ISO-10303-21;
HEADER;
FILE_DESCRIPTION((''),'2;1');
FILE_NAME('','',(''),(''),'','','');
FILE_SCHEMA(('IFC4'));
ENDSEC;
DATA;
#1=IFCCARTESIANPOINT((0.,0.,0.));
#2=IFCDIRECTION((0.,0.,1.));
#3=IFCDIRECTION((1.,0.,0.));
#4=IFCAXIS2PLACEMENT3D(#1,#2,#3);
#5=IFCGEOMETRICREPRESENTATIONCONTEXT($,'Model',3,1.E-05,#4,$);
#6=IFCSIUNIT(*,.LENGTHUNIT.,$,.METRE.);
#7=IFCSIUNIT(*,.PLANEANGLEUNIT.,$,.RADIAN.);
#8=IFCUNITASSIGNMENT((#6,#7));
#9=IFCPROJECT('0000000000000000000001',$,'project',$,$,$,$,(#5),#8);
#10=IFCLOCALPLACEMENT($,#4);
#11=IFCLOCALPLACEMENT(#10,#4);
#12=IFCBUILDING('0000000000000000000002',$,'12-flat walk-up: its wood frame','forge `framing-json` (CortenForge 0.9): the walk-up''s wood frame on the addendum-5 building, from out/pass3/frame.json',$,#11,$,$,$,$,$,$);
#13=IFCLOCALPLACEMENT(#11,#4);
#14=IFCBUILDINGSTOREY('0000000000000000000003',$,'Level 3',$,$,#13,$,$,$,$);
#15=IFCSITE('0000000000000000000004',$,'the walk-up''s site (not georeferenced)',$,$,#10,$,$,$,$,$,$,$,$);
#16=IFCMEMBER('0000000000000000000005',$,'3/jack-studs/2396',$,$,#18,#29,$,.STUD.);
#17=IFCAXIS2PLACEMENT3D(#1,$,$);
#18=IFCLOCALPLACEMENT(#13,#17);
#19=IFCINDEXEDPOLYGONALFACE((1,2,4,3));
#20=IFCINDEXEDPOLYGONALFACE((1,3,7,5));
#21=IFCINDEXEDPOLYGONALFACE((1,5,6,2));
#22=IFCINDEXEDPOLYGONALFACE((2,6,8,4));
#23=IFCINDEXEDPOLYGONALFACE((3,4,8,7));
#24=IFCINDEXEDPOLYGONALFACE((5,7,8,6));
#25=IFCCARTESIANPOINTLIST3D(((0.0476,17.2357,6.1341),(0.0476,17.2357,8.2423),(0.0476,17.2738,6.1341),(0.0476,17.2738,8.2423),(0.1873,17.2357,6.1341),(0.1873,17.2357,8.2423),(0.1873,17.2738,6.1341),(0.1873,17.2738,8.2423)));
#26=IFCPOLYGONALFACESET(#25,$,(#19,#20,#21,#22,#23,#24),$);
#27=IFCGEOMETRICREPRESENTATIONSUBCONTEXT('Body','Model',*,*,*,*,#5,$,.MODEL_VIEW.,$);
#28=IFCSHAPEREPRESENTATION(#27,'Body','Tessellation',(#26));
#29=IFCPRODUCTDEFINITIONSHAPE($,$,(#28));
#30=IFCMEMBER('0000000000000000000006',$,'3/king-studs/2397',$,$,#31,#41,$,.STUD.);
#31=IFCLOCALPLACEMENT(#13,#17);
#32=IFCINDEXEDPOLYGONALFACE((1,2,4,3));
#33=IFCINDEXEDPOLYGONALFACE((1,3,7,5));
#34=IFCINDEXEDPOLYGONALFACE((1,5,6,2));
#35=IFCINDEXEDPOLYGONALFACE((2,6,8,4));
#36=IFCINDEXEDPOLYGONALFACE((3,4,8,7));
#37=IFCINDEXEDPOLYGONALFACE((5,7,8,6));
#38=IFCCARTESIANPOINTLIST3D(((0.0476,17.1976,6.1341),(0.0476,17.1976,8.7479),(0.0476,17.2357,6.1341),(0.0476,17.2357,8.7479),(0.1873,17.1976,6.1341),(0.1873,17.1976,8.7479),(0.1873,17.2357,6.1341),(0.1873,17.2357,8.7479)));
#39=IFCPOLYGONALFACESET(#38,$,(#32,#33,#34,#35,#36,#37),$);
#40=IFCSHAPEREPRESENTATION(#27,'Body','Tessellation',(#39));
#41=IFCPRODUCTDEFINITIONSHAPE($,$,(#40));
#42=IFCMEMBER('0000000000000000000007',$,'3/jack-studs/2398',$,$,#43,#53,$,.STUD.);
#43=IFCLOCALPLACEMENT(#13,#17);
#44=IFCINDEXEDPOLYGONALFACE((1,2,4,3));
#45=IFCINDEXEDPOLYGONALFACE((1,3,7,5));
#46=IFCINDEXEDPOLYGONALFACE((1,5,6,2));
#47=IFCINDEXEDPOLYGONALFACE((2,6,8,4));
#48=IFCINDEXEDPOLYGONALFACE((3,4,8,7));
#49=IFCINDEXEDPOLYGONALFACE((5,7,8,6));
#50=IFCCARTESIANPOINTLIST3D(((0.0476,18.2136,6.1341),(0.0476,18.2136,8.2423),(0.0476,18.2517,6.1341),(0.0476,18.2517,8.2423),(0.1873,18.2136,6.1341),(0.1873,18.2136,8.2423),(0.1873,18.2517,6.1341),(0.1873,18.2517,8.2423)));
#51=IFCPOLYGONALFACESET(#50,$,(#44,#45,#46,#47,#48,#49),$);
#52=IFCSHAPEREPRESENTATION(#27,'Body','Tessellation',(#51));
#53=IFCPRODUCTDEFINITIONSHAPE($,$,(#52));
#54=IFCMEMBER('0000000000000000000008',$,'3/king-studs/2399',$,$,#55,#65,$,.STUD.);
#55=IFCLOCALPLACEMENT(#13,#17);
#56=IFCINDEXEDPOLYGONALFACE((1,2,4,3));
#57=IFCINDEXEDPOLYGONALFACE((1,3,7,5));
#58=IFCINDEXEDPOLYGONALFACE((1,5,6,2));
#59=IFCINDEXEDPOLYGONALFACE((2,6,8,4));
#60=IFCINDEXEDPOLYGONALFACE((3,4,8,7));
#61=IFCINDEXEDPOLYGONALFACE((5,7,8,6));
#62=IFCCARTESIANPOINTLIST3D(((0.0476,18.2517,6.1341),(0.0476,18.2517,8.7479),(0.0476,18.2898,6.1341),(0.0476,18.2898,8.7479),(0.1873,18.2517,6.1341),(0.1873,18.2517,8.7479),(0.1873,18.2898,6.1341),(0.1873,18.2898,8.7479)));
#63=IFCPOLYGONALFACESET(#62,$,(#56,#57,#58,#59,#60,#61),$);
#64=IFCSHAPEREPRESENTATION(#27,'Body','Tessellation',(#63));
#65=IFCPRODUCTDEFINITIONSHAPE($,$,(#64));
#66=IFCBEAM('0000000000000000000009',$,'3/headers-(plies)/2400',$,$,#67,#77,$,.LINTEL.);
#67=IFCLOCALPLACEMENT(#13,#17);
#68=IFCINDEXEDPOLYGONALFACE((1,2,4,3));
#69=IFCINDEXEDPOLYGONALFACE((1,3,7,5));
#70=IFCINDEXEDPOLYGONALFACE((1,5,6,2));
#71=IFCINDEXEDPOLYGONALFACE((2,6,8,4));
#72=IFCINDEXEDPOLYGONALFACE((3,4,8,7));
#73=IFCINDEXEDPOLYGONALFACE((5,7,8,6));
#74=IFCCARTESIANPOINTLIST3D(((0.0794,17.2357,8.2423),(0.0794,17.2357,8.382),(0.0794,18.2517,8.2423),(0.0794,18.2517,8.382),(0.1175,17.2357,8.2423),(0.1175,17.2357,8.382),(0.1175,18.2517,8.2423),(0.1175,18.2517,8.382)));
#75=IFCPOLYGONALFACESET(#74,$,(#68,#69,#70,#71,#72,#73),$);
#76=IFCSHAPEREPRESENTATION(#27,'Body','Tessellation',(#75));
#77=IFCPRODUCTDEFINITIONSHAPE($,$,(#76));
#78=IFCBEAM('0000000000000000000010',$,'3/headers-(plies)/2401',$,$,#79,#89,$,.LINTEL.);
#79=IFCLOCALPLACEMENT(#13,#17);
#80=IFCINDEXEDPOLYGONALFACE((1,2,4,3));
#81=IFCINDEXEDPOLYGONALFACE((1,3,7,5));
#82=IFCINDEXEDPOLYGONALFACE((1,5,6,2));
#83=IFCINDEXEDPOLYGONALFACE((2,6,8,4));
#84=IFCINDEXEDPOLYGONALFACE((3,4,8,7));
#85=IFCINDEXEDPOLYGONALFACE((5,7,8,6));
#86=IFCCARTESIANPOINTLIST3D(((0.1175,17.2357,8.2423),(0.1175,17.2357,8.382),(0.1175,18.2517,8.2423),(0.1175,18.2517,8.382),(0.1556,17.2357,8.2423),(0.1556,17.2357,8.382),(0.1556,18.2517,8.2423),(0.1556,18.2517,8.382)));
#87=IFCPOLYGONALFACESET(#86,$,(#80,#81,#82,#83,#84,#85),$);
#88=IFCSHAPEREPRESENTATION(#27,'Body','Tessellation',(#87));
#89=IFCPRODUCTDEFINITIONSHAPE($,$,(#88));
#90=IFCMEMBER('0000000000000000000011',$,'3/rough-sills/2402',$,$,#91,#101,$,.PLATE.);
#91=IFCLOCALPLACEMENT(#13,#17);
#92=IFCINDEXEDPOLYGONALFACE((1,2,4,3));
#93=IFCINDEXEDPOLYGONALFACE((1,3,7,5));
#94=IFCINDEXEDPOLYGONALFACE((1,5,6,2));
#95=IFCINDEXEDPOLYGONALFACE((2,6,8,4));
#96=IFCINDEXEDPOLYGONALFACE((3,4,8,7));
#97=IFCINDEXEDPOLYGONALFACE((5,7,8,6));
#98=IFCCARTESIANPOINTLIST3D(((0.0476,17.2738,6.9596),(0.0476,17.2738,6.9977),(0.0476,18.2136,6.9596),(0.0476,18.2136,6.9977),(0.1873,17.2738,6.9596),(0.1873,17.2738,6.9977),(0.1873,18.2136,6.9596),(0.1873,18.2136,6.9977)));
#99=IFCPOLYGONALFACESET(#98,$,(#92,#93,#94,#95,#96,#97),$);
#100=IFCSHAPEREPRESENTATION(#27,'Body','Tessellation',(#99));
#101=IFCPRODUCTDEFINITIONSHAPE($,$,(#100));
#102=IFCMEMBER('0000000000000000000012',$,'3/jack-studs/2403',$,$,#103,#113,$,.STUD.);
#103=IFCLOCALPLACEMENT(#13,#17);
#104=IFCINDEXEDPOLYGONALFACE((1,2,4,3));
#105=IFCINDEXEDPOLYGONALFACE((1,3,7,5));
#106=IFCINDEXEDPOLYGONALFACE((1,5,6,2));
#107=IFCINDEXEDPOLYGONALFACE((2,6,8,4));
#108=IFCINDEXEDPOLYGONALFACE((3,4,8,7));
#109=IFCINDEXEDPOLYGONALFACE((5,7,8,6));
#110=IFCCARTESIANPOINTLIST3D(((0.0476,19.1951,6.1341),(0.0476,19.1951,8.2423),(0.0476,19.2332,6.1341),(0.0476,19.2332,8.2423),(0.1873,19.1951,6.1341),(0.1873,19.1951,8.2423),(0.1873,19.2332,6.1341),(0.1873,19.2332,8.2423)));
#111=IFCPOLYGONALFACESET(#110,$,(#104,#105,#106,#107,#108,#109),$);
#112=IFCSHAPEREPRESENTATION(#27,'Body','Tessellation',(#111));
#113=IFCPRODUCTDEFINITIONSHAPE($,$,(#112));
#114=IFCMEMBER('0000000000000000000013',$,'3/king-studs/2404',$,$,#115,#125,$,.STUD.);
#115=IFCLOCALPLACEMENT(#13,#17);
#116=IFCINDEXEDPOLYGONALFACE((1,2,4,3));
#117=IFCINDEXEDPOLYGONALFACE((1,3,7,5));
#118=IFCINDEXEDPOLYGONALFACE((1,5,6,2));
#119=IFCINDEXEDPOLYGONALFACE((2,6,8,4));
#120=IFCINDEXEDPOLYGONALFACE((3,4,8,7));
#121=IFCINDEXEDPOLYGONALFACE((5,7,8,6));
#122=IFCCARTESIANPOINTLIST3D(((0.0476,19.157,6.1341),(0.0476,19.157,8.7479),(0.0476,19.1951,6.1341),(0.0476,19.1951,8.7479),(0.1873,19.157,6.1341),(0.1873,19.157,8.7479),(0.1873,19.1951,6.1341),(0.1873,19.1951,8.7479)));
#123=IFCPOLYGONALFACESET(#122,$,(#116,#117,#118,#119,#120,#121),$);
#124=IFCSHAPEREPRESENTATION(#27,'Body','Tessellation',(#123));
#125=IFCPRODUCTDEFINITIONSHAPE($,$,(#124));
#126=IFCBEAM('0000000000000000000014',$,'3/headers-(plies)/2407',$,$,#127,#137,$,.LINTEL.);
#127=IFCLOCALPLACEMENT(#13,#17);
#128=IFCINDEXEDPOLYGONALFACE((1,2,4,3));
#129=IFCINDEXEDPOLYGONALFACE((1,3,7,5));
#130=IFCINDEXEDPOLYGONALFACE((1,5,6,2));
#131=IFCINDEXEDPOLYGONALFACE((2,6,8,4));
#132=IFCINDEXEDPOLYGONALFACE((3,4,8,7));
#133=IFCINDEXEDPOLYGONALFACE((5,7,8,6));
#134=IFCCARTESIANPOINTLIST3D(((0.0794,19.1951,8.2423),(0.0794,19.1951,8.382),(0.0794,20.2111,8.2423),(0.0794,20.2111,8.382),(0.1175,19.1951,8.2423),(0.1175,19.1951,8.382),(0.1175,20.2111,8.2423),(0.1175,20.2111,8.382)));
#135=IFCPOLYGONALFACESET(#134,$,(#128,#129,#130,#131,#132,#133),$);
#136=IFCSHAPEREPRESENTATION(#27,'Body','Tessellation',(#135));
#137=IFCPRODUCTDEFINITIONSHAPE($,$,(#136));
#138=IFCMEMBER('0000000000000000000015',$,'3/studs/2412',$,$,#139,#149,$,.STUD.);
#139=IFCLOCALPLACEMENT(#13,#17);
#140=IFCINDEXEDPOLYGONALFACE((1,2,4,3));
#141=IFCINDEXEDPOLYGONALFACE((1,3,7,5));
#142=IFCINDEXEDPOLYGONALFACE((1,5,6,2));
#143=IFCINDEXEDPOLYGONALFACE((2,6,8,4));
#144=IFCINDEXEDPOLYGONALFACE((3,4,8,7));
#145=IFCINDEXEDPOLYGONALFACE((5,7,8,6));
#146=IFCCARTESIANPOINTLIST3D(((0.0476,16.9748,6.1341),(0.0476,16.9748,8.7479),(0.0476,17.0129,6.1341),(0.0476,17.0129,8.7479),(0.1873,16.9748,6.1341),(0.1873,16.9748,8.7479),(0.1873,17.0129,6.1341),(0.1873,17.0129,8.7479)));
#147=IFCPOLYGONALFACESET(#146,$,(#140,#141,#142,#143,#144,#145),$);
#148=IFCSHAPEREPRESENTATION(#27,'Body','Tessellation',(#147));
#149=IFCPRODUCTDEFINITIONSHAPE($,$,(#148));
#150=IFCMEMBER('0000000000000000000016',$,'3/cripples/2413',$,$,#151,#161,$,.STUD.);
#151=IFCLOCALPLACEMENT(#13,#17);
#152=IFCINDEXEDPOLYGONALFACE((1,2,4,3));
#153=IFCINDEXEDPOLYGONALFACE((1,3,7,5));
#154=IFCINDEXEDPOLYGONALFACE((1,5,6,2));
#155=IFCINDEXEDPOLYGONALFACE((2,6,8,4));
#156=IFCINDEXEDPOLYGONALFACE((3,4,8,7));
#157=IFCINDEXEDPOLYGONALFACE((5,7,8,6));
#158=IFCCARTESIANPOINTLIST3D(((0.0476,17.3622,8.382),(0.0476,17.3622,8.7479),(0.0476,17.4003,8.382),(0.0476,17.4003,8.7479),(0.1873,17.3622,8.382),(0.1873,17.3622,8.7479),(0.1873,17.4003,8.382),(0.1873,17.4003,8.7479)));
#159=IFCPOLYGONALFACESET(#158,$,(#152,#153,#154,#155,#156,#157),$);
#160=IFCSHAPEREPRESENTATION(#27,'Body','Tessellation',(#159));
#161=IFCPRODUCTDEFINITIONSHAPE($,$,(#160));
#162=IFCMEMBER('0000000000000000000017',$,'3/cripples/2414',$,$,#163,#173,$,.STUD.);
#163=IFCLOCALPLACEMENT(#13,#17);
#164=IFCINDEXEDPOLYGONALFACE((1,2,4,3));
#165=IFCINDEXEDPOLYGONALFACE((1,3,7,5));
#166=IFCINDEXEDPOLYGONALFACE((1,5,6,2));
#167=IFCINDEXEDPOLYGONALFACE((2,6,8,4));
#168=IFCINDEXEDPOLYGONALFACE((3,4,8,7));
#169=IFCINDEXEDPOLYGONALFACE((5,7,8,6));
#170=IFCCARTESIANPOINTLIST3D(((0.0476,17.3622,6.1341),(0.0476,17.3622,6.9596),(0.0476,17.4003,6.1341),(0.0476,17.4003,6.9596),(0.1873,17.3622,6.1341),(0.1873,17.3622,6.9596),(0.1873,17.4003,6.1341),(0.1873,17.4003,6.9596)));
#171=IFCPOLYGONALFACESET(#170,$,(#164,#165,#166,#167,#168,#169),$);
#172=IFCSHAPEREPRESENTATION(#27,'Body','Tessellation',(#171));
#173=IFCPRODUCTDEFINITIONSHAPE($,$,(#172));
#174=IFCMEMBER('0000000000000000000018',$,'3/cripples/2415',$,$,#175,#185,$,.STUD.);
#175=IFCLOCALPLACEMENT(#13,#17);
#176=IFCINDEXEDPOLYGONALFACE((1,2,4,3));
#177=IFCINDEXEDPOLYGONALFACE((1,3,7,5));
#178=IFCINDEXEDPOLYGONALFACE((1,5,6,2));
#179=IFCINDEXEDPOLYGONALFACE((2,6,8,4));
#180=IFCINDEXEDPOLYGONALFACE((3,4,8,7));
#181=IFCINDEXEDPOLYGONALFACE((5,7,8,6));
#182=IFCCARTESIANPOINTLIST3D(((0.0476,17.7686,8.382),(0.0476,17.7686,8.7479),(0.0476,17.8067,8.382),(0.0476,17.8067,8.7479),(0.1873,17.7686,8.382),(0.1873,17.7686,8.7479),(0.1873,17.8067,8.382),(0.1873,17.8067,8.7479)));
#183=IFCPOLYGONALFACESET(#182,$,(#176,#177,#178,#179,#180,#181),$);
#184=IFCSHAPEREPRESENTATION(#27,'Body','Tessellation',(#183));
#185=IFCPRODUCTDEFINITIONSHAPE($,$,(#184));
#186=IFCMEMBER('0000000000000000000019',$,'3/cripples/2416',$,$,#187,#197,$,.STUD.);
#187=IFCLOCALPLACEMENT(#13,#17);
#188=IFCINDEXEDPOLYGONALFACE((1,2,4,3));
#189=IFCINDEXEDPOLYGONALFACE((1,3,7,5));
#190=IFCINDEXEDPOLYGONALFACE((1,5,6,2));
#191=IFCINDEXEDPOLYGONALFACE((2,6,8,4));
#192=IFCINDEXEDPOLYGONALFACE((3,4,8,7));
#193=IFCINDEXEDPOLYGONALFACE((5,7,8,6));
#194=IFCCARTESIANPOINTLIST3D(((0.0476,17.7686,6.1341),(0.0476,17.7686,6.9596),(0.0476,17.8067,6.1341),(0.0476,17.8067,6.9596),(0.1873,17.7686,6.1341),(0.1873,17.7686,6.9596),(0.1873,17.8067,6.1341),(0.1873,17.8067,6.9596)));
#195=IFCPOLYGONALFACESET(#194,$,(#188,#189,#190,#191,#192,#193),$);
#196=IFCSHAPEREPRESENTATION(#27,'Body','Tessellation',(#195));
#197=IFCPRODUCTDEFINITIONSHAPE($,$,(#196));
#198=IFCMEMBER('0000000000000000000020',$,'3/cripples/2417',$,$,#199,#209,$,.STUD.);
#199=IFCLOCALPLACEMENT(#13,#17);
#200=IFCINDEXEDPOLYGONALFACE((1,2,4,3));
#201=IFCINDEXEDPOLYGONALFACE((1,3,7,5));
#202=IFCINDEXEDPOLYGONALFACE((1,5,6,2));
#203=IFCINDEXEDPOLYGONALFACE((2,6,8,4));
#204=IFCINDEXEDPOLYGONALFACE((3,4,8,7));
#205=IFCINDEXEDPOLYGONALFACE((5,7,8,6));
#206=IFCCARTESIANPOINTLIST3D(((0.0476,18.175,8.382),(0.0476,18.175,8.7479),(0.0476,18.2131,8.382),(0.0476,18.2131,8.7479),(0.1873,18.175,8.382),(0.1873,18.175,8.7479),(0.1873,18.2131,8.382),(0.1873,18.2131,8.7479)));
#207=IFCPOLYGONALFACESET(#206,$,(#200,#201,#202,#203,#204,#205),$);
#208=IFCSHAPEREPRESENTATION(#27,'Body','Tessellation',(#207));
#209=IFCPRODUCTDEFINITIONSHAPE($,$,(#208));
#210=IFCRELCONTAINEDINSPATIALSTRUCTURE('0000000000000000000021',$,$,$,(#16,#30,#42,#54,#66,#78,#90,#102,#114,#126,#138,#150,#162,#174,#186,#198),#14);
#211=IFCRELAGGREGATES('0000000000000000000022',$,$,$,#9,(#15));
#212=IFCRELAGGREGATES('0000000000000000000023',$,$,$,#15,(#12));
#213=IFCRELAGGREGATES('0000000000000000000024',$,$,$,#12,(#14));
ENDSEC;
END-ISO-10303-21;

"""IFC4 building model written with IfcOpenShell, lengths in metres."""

from ifc_helpers import new_model, si_unit, frame, frame_2d, origin, origin_with_axes, place, context, subcontext, project, spatial, rectangle, extrude, element, save


model = new_model("IFC4")

# Units and contexts
model_context = context("Model", 3, precision=1e-05, world=origin_with_axes())
body_context = subcontext(model_context, "Body", "Model", "MODEL_VIEW")
ifc_project = project(units=[si_unit("LENGTHUNIT", "METRE"), si_unit("PLANEANGLEUNIT", "RADIAN")], contexts=[model_context])

# Site, building, storey
site_placement = place(None, origin_with_axes())
site = spatial("IfcSite", under=ifc_project, at=site_placement, Name="the walk-up's site (not georeferenced)")
building_placement = place(site_placement, origin_with_axes())
building = spatial("IfcBuilding", under=site, at=building_placement, Name="12-flat walk-up: its wood frame", Description="forge `framing-json` (CortenForge 0.9): the walk-up's wood frame on the addendum-5 building, from out/pass3/frame.json")
storey_placement = place(building_placement, origin_with_axes())
storey = spatial("IfcBuildingStorey", under=building, at=storey_placement, Name="Level 3")

# Members
member_1_placement = place(storey_placement, frame((0.0476, 17.2357, 6.1341), z_axis=(0.0, 0.0, 1.0), x_axis=(1.0, 0.0, 0.0)))
element("IfcMember", 1, at=member_1_placement, inside=storey, Name="3/jack-studs/2396", PredefinedType="STUD", context=body_context, shape_type="SweptSolid", body=[
    extrude(rectangle(XDim=0.1397, YDim=0.0381, at=frame_2d((0.0698, 0.0191))), origin(), (0.0, 0.0, 1.0), 2.1082),
])
member_2_placement = place(storey_placement, frame((0.0476, 17.1976, 6.1341), z_axis=(0.0, 0.0, 1.0), x_axis=(1.0, 0.0, 0.0)))
element("IfcMember", 2, at=member_2_placement, inside=storey, Name="3/king-studs/2397", PredefinedType="STUD", context=body_context, shape_type="SweptSolid", body=[
    extrude(rectangle(XDim=0.1397, YDim=0.0381, at=frame_2d((0.0698, 0.0191))), origin(), (0.0, 0.0, 1.0), 2.6138),
])
member_3_placement = place(storey_placement, frame((0.0476, 18.2136, 6.1341), z_axis=(0.0, 0.0, 1.0), x_axis=(1.0, 0.0, 0.0)))
element("IfcMember", 3, at=member_3_placement, inside=storey, Name="3/jack-studs/2398", PredefinedType="STUD", context=body_context, shape_type="SweptSolid", body=[
    extrude(rectangle(XDim=0.1397, YDim=0.0381, at=frame_2d((0.0698, 0.0191))), origin(), (0.0, 0.0, 1.0), 2.1082),
])
member_4_placement = place(storey_placement, frame((0.0476, 18.2517, 6.1341), z_axis=(0.0, 0.0, 1.0), x_axis=(1.0, 0.0, 0.0)))
element("IfcMember", 4, at=member_4_placement, inside=storey, Name="3/king-studs/2399", PredefinedType="STUD", context=body_context, shape_type="SweptSolid", body=[
    extrude(rectangle(XDim=0.1397, YDim=0.0381, at=frame_2d((0.0698, 0.0191))), origin(), (0.0, 0.0, 1.0), 2.6138),
])

# Beams
for number, where, z_axis, x_axis, name in (
    (5, (0.0794, 17.2357, 8.2423), (0.0, 0.0, 1.0), (1.0, 0.0, 0.0), "3/headers-(plies)/2400"),
    (6, (0.1175, 17.2357, 8.2423), (0.0, 0.0, 1.0), (1.0, 0.0, 0.0), "3/headers-(plies)/2401"),
):
    element("IfcBeam", number, at=place(storey_placement, frame(where, z_axis=z_axis, x_axis=x_axis)), inside=storey, Name=name, PredefinedType="LINTEL", context=body_context, shape_type="SweptSolid", body=[
        extrude(rectangle(XDim=0.0381, YDim=1.016, at=frame_2d((0.019, 0.508))), origin(), (0.0, 0.0, 1.0), 0.1397),
    ])

# Members
member_5_placement = place(storey_placement, frame((0.0476, 17.2738, 6.9596), z_axis=(0.0, 0.0, 1.0), x_axis=(1.0, 0.0, 0.0)))
element("IfcMember", 7, at=member_5_placement, inside=storey, Name="3/rough-sills/2402", PredefinedType="PLATE", context=body_context, shape_type="SweptSolid", body=[
    extrude(rectangle(XDim=0.1397, YDim=0.9398, at=frame_2d((0.0698, 0.4699))), origin(), (0.0, 0.0, 1.0), 0.0381),
])
member_6_placement = place(storey_placement, frame((0.0476, 19.1951, 6.1341), z_axis=(0.0, 0.0, 1.0), x_axis=(1.0, 0.0, 0.0)))
element("IfcMember", 8, at=member_6_placement, inside=storey, Name="3/jack-studs/2403", PredefinedType="STUD", context=body_context, shape_type="SweptSolid", body=[
    extrude(rectangle(XDim=0.1397, YDim=0.0381, at=frame_2d((0.0698, 0.0191))), origin(), (0.0, 0.0, 1.0), 2.1082),
])
member_7_placement = place(storey_placement, frame((0.0476, 19.157, 6.1341), z_axis=(0.0, 0.0, 1.0), x_axis=(1.0, 0.0, 0.0)))
element("IfcMember", 9, at=member_7_placement, inside=storey, Name="3/king-studs/2404", PredefinedType="STUD", context=body_context, shape_type="SweptSolid", body=[
    extrude(rectangle(XDim=0.1397, YDim=0.0381, at=frame_2d((0.0698, 0.0191))), origin(), (0.0, 0.0, 1.0), 2.6138),
])

# Beam
beam_placement = place(storey_placement, frame((0.0794, 19.1951, 8.2423), z_axis=(0.0, 0.0, 1.0), x_axis=(1.0, 0.0, 0.0)))
element("IfcBeam", 10, at=beam_placement, inside=storey, Name="3/headers-(plies)/2407", PredefinedType="LINTEL", context=body_context, shape_type="SweptSolid", body=[
    extrude(rectangle(XDim=0.0381, YDim=1.016, at=frame_2d((0.019, 0.508))), origin(), (0.0, 0.0, 1.0), 0.1397),
])

# Members
member_8_placement = place(storey_placement, frame((0.0476, 16.9748, 6.1341), z_axis=(0.0, 0.0, 1.0), x_axis=(1.0, 0.0, 0.0)))
element("IfcMember", 11, at=member_8_placement, inside=storey, Name="3/studs/2412", PredefinedType="STUD", context=body_context, shape_type="SweptSolid", body=[
    extrude(rectangle(XDim=0.1397, YDim=0.0381, at=frame_2d((0.0698, 0.0191))), origin(), (0.0, 0.0, 1.0), 2.6138),
])
member_9_placement = place(storey_placement, frame((0.0476, 17.3622, 8.382), z_axis=(0.0, 0.0, 1.0), x_axis=(1.0, 0.0, 0.0)))
element("IfcMember", 12, at=member_9_placement, inside=storey, Name="3/cripples/2413", PredefinedType="STUD", context=body_context, shape_type="SweptSolid", body=[
    extrude(rectangle(XDim=0.1397, YDim=0.0381, at=frame_2d((0.0698, 0.0191))), origin(), (0.0, 0.0, 1.0), 0.3659),
])
member_10_placement = place(storey_placement, frame((0.0476, 17.3622, 6.1341), z_axis=(0.0, 0.0, 1.0), x_axis=(1.0, 0.0, 0.0)))
element("IfcMember", 13, at=member_10_placement, inside=storey, Name="3/cripples/2414", PredefinedType="STUD", context=body_context, shape_type="SweptSolid", body=[
    extrude(rectangle(XDim=0.1397, YDim=0.0381, at=frame_2d((0.0698, 0.0191))), origin(), (0.0, 0.0, 1.0), 0.8255),
])
member_11_placement = place(storey_placement, frame((0.0476, 17.7686, 8.382), z_axis=(0.0, 0.0, 1.0), x_axis=(1.0, 0.0, 0.0)))
element("IfcMember", 14, at=member_11_placement, inside=storey, Name="3/cripples/2415", PredefinedType="STUD", context=body_context, shape_type="SweptSolid", body=[
    extrude(rectangle(XDim=0.1397, YDim=0.0381, at=frame_2d((0.0698, 0.0191))), origin(), (0.0, 0.0, 1.0), 0.3659),
])
member_12_placement = place(storey_placement, frame((0.0476, 17.7686, 6.1341), z_axis=(0.0, 0.0, 1.0), x_axis=(1.0, 0.0, 0.0)))
element("IfcMember", 15, at=member_12_placement, inside=storey, Name="3/cripples/2416", PredefinedType="STUD", context=body_context, shape_type="SweptSolid", body=[
    extrude(rectangle(XDim=0.1397, YDim=0.0381, at=frame_2d((0.0698, 0.0191))), origin(), (0.0, 0.0, 1.0), 0.8255),
])
member_13_placement = place(storey_placement, frame((0.0476, 18.175, 8.382), z_axis=(0.0, 0.0, 1.0), x_axis=(1.0, 0.0, 0.0)))
element("IfcMember", 16, at=member_13_placement, inside=storey, Name="3/cripples/2417", PredefinedType="STUD", context=body_context, shape_type="SweptSolid", body=[
    extrude(rectangle(XDim=0.1397, YDim=0.0381, at=frame_2d((0.0698, 0.0191))), origin(), (0.0, 0.0, 1.0), 0.3659),
])

save(model, "model.ifc")
